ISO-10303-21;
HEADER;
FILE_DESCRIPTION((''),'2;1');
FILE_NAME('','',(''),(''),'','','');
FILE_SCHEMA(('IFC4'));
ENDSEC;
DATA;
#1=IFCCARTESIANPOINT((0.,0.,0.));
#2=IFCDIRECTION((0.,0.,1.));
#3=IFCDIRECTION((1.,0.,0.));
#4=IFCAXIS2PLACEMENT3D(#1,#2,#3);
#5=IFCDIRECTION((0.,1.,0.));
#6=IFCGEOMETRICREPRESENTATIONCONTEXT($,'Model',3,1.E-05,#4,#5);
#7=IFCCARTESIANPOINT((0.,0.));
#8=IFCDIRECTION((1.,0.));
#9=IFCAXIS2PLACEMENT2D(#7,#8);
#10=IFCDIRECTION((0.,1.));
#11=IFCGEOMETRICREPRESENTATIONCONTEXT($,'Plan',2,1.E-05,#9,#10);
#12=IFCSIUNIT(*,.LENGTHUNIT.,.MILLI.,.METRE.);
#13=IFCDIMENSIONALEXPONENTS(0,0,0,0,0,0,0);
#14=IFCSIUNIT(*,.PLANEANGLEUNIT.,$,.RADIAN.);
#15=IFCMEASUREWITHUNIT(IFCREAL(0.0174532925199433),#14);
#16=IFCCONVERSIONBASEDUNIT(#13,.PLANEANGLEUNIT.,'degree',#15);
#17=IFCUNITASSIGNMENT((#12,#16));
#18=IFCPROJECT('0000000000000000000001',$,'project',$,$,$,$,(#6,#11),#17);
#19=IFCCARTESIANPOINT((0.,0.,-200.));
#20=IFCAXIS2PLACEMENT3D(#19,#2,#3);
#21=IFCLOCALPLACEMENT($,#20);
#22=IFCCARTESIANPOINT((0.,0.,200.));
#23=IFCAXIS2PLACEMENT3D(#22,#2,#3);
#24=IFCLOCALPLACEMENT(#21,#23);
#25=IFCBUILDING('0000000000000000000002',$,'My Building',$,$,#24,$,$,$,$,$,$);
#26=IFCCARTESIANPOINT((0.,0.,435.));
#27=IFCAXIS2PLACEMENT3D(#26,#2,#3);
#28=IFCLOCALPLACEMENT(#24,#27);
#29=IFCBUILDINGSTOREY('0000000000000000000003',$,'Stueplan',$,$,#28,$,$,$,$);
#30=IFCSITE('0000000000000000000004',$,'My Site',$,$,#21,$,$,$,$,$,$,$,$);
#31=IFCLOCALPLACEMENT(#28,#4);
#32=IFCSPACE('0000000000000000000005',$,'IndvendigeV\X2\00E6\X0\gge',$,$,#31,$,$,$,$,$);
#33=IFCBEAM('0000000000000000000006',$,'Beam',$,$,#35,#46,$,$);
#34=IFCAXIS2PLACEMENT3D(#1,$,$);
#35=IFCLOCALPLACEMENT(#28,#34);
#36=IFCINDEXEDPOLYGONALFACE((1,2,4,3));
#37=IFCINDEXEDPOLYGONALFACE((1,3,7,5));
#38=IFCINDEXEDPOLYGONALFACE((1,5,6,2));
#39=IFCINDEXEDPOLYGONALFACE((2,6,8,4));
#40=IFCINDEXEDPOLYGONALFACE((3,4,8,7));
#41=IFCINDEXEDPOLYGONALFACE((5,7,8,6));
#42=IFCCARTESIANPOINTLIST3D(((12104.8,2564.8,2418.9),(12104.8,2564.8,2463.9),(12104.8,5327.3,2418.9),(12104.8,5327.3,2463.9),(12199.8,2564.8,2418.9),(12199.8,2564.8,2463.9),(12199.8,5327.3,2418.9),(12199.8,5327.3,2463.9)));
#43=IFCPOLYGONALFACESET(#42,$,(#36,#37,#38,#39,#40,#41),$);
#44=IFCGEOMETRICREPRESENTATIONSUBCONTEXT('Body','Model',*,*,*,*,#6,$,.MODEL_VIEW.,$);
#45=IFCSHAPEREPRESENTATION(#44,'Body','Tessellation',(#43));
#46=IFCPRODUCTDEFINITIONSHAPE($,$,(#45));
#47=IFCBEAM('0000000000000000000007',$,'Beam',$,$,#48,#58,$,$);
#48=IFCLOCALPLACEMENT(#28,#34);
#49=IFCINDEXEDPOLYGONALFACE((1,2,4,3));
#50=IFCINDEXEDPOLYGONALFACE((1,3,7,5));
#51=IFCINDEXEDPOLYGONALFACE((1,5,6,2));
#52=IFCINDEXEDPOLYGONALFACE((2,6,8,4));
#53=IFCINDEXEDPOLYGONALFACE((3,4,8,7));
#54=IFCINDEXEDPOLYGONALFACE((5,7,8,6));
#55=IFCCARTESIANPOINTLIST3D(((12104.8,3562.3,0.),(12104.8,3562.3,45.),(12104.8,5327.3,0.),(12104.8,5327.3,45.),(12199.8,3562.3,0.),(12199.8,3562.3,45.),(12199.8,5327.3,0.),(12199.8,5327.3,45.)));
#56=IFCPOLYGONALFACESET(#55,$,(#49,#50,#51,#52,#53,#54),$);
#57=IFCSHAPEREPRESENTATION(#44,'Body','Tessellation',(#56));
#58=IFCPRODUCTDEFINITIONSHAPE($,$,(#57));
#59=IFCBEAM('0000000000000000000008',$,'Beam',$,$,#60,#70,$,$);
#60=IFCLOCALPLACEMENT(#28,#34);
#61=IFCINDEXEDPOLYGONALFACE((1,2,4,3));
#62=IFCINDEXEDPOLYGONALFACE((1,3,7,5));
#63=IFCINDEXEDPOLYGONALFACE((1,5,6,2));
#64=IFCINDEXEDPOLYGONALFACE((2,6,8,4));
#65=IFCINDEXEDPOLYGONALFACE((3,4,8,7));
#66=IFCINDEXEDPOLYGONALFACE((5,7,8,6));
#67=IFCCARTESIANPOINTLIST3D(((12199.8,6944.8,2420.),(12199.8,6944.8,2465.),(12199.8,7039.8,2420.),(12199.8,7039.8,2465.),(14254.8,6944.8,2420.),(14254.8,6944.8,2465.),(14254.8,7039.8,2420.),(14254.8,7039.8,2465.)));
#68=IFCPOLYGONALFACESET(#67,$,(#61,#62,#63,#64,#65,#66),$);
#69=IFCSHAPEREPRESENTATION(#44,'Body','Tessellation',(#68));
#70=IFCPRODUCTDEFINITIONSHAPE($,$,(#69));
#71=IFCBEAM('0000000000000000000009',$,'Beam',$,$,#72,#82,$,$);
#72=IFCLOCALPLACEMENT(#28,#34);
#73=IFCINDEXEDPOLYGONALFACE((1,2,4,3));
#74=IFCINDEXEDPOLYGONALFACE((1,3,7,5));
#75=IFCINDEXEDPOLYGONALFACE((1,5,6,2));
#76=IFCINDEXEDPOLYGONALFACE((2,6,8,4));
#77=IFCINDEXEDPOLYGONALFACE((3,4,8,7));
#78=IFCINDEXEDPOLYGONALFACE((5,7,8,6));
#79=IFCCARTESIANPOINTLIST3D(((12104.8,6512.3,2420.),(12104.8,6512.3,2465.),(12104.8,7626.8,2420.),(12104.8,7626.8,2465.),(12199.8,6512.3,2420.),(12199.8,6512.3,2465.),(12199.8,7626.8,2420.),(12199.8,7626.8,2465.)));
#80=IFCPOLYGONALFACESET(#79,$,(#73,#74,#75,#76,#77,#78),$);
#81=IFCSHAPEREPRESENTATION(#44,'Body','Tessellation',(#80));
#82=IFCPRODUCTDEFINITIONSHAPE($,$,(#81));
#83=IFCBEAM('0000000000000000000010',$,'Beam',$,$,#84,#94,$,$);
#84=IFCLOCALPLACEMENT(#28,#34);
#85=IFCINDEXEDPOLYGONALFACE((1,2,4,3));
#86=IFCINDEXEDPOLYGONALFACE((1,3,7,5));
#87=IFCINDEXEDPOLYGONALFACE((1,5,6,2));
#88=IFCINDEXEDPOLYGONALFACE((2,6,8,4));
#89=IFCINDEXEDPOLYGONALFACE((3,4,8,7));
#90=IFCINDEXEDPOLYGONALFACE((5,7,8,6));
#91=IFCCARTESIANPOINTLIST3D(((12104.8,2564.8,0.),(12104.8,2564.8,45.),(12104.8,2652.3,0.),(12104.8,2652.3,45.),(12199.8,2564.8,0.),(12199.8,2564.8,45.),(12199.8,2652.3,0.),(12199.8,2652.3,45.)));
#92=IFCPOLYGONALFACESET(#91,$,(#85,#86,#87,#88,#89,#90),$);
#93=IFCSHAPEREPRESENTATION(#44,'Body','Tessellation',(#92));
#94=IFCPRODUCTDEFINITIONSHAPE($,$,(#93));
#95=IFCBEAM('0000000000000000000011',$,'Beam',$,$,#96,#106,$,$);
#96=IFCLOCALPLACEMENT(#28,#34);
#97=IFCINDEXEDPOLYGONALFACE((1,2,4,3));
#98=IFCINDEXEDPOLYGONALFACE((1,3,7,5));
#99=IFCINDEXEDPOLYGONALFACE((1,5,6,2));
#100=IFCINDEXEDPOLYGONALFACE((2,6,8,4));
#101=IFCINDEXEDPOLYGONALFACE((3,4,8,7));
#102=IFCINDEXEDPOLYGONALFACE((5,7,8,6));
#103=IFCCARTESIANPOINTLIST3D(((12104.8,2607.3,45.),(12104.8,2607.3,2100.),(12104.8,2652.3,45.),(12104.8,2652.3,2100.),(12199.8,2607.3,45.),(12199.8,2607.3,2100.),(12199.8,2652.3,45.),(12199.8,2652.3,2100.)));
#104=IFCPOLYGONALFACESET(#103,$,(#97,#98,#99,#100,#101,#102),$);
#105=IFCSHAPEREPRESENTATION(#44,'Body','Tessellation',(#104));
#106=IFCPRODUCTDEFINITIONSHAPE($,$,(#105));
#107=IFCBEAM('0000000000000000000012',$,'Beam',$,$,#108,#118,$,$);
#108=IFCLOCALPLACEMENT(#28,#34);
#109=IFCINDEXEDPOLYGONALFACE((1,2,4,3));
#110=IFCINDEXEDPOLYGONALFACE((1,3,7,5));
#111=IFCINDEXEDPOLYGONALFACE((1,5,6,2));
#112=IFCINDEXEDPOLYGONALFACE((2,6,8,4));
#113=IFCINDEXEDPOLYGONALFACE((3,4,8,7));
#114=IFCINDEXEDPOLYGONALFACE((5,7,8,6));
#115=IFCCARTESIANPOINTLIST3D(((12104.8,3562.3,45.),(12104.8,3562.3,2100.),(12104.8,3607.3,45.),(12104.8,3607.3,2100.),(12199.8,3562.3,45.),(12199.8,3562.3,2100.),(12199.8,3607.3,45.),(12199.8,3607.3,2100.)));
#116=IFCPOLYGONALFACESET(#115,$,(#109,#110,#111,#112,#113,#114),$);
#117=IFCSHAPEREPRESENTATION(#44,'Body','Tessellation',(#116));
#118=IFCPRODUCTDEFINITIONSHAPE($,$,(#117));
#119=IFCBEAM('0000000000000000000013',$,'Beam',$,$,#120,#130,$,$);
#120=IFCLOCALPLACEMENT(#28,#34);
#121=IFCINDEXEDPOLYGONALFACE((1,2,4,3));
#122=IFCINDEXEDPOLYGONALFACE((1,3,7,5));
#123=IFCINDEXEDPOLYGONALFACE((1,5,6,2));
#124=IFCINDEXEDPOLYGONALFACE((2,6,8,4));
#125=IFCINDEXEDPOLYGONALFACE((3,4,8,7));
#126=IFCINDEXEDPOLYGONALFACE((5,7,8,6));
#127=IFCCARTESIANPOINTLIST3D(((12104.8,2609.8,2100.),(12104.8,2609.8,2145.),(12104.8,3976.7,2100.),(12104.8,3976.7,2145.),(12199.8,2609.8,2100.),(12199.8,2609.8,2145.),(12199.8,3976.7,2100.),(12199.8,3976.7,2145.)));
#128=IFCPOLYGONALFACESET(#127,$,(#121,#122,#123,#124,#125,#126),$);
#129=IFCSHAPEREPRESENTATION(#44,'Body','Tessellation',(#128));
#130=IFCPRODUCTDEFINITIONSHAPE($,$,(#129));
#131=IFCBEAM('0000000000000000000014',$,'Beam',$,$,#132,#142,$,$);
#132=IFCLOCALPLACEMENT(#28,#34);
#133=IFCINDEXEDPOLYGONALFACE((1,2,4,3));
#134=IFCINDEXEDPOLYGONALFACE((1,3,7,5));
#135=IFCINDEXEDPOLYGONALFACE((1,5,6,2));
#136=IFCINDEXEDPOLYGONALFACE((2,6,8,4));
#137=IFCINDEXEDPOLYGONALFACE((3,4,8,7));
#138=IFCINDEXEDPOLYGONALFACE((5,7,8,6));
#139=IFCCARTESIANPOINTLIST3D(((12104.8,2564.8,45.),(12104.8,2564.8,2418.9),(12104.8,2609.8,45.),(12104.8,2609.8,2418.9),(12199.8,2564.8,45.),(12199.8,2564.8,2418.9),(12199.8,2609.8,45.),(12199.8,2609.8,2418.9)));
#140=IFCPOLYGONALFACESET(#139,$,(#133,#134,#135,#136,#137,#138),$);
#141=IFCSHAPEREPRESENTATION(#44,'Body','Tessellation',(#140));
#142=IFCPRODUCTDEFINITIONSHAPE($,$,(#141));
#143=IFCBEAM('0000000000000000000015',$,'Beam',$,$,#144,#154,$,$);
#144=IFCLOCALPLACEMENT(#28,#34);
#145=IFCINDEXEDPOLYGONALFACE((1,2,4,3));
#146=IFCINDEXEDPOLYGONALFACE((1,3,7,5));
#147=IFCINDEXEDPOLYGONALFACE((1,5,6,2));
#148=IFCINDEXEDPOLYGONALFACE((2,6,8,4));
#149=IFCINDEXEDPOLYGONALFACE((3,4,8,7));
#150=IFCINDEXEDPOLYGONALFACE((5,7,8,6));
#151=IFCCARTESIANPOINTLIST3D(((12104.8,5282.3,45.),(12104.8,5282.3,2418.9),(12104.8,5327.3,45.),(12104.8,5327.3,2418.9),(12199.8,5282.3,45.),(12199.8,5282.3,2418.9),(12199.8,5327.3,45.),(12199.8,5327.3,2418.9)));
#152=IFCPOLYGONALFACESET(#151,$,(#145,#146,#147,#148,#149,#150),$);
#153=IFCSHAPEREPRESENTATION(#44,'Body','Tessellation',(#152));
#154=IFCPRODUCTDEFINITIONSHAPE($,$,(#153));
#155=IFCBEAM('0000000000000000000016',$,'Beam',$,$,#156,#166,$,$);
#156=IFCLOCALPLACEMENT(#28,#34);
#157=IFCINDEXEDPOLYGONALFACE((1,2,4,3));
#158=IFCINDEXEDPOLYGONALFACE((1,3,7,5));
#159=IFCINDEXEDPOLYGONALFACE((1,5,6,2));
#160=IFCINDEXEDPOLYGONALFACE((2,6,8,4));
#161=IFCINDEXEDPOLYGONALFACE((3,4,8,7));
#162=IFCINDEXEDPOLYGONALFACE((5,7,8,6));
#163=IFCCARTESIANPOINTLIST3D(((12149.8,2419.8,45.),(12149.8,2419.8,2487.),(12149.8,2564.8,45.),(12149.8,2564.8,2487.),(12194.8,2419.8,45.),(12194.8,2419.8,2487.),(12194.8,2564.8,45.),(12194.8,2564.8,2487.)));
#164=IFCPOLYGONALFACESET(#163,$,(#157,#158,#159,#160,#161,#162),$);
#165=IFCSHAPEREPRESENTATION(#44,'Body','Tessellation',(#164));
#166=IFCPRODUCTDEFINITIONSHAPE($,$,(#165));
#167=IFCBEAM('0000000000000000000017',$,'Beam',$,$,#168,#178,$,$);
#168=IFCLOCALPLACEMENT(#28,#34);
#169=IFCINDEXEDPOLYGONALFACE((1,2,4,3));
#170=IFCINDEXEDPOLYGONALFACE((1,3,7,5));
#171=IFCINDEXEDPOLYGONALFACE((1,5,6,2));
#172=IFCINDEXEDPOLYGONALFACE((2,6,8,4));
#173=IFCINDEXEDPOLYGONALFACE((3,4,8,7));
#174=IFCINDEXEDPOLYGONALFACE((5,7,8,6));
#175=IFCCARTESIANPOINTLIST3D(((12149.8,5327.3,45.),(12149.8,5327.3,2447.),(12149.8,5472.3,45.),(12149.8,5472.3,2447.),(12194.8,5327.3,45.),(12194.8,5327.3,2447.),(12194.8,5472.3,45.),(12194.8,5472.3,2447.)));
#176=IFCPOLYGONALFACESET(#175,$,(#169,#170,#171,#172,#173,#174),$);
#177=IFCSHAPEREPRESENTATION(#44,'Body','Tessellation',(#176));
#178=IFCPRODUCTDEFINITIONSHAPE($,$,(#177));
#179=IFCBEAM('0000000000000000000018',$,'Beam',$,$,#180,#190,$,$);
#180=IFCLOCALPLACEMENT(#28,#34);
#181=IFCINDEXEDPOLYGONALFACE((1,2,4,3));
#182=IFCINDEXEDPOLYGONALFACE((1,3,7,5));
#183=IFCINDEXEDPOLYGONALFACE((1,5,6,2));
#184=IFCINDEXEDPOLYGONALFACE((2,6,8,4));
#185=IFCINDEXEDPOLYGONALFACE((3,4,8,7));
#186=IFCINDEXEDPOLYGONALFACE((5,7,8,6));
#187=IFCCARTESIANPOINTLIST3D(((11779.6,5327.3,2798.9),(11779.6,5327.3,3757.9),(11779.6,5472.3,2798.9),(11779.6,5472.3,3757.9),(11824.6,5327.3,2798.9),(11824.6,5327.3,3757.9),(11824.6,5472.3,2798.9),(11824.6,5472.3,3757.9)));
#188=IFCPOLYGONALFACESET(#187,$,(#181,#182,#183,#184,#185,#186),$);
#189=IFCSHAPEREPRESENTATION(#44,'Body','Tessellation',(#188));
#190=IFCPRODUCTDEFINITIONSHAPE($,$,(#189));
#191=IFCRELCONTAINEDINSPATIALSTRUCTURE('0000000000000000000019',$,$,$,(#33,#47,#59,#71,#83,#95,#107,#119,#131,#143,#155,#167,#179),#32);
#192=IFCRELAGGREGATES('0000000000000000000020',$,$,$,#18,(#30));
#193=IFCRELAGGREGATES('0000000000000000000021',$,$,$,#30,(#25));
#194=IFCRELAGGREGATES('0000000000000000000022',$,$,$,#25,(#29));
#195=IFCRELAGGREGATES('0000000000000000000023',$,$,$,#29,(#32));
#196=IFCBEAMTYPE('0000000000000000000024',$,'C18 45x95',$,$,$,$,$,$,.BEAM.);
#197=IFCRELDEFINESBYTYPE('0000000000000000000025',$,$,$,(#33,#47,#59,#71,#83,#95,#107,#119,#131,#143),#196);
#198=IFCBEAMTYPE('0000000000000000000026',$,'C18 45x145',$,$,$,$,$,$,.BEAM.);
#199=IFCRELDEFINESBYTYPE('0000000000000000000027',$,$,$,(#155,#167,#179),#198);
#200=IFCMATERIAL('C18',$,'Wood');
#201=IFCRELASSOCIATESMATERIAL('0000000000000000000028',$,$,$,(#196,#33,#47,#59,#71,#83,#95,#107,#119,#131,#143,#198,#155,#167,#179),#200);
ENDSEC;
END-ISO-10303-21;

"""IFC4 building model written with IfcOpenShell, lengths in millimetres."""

from ifc_helpers import new_model, entity, si_unit, converted_unit, direction, frame, origin_with_axes, origin_2d_with_axis, place, context, subcontext, project, spatial, rectangle, extrude, material, material_profile, profile_set, profile_usage, type_object, element, save


model = new_model("IFC4")

# Units and contexts
model_context = context("Model", 3, precision=1e-05, world=origin_with_axes(), true_north=direction((0.0, 1.0, 0.0)))
plan_context = context("Plan", 2, precision=1e-05, world=origin_2d_with_axis(), true_north=direction((0.0, 1.0)))
body_context_1 = subcontext(model_context, "Body", "Model", "MODEL_VIEW")
ifc_project = project(units=[si_unit("LENGTHUNIT", "METRE", prefix="MILLI"), converted_unit("PLANEANGLEUNIT", "degree", entity("IfcReal", 0.0174532925199433), si_unit("PLANEANGLEUNIT", "RADIAN"), dimensions=[0, 0, 0, 0, 0, 0, 0])], contexts=[model_context, plan_context])

# Site, building, storey, space
site_placement = place(None, frame((0.0, 0.0, -200.0), z_axis=(0.0, 0.0, 1.0), x_axis=(1.0, 0.0, 0.0)))
site = spatial("IfcSite", under=ifc_project, at=site_placement, Name="My Site")
building_placement = place(site_placement, frame((0.0, 0.0, 200.0), z_axis=(0.0, 0.0, 1.0), x_axis=(1.0, 0.0, 0.0)))
building = spatial("IfcBuilding", under=site, at=building_placement, Name="My Building")
storey_placement = place(building_placement, frame((0.0, 0.0, 435.0), z_axis=(0.0, 0.0, 1.0), x_axis=(1.0, 0.0, 0.0)))
storey = spatial("IfcBuildingStorey", under=building, at=storey_placement, Name="Stueplan")
space_1_placement = place(storey_placement, frame((0.0, 0.0, 0.0), z_axis=(0.0, 0.0, 1.0), x_axis=(1.0, 0.0, 0.0)))
space_1 = spatial("IfcSpace", under=storey, at=space_1_placement, Name="IndvendigeVægge")

# Beams
ifc_material = material(Name="C18", Category="Wood")
ifc_material_profile_1 = material_profile(ifc_material, rectangle(XDim=45.0, YDim=95.0))
ifc_profile_set_1 = profile_set([ifc_material_profile_1], Name="woodStructural")
beam_type_1 = type_object("IfcBeamType", Name="C18 45x95", PredefinedType="BEAM", material=ifc_profile_set_1)
ifc_profile_usage_1 = profile_usage(ifc_profile_set_1, cardinal=5)
beam_1_placement = place(space_1_placement, frame((12152.3, 2564.8, 2441.4), z_axis=(0.0, 1.0, 0.0), x_axis=(0.0, 0.0, 1.0)))
element("IfcBeam", 1, at=beam_1_placement, inside=space_1, type_object=beam_type_1, material=ifc_profile_usage_1, Name="Beam", context=body_context_1, shape_type="SweptSolid", body=[
    extrude(rectangle(XDim=45.0, YDim=95.0), origin_with_axes(), (0.0, 0.0, 1.0), 2762.5),
])
ifc_profile_usage_2 = profile_usage(ifc_profile_set_1, cardinal=5)
beam_2_placement = place(space_1_placement, frame((12152.3, 3562.3, 22.5), z_axis=(0.0, 1.0, 0.0), x_axis=(0.0, 0.0, 1.0)))
element("IfcBeam", 2, at=beam_2_placement, inside=space_1, type_object=beam_type_1, material=ifc_profile_usage_2, Name="Beam", context=body_context_1, shape_type="SweptSolid", body=[
    extrude(rectangle(XDim=45.0, YDim=95.0), origin_with_axes(), (0.0, 0.0, 1.0), 1765.0),
])
ifc_profile_usage_3 = profile_usage(ifc_profile_set_1, cardinal=5)
beam_3_placement = place(space_1_placement, frame((12199.8, 6992.3, 2442.5), z_axis=(1.0, 0.0, 0.0), x_axis=(0.0, 0.0, 1.0)))
element("IfcBeam", 3, at=beam_3_placement, inside=space_1, type_object=beam_type_1, material=ifc_profile_usage_3, Name="Beam", context=body_context_1, shape_type="SweptSolid", body=[
    extrude(rectangle(XDim=45.0, YDim=95.0), origin_with_axes(), (0.0, 0.0, 1.0), 2055.0),
])
ifc_profile_usage_4 = profile_usage(ifc_profile_set_1, cardinal=5)
beam_4_placement = place(space_1_placement, frame((12152.3, 6512.3, 2442.5), z_axis=(0.0, 1.0, 0.0), x_axis=(0.0, 0.0, 1.0)))
element("IfcBeam", 4, at=beam_4_placement, inside=space_1, type_object=beam_type_1, material=ifc_profile_usage_4, Name="Beam", context=body_context_1, shape_type="SweptSolid", body=[
    extrude(rectangle(XDim=45.0, YDim=95.0), origin_with_axes(), (0.0, 0.0, 1.0), 1114.5),
])
ifc_profile_usage_5 = profile_usage(ifc_profile_set_1, cardinal=5)
beam_5_placement = place(space_1_placement, frame((12152.3, 2652.3, 22.5), z_axis=(0.0, -1.0, 0.0), x_axis=(0.0, 0.0, 1.0)))
element("IfcBeam", 5, at=beam_5_placement, inside=space_1, type_object=beam_type_1, material=ifc_profile_usage_5, Name="Beam", context=body_context_1, shape_type="SweptSolid", body=[
    extrude(rectangle(XDim=45.0, YDim=95.0), origin_with_axes(), (0.0, 0.0, 1.0), 87.5),
])
ifc_profile_usage_6 = profile_usage(ifc_profile_set_1)
beam_6_placement = place(space_1_placement, frame((12152.3, 2629.8, 45.0), z_axis=(0.0, 0.0, 1.0), x_axis=(0.0, -1.0, 0.0)))
element("IfcBeam", 6, at=beam_6_placement, inside=space_1, type_object=beam_type_1, material=ifc_profile_usage_6, Name="Beam", context=body_context_1, shape_type="SweptSolid", body=[
    extrude(rectangle(XDim=45.0, YDim=95.0), origin_with_axes(), (0.0, 0.0, 1.0), 2055.0),
])
ifc_profile_usage_7 = profile_usage(ifc_profile_set_1)
beam_7_placement = place(space_1_placement, frame((12152.3, 3584.8, 45.0), z_axis=(0.0, 0.0, 1.0), x_axis=(0.0, -1.0, 0.0)))
element("IfcBeam", 7, at=beam_7_placement, inside=space_1, type_object=beam_type_1, material=ifc_profile_usage_7, Name="Beam", context=body_context_1, shape_type="SweptSolid", body=[
    extrude(rectangle(XDim=45.0, YDim=95.0), origin_with_axes(), (0.0, 0.0, 1.0), 2055.0),
])
ifc_profile_usage_8 = profile_usage(ifc_profile_set_1, cardinal=5)
beam_8_placement = place(space_1_placement, frame((12152.3, 3976.7, 2122.5), z_axis=(0.0, -1.0, 0.0), x_axis=(0.0, 0.0, 1.0)))
element("IfcBeam", 8, at=beam_8_placement, inside=space_1, type_object=beam_type_1, material=ifc_profile_usage_8, Name="Beam", context=body_context_1, shape_type="SweptSolid", body=[
    extrude(rectangle(XDim=45.0, YDim=95.0), origin_with_axes(), (0.0, 0.0, 1.0), 1366.9),
])
ifc_profile_usage_9 = profile_usage(ifc_profile_set_1)
beam_9_placement = place(space_1_placement, frame((12152.3, 2587.3, 45.0), z_axis=(0.0, 0.0, 1.0), x_axis=(0.0, -1.0, 0.0)))
element("IfcBeam", 9, at=beam_9_placement, inside=space_1, type_object=beam_type_1, material=ifc_profile_usage_9, Name="Beam", context=body_context_1, shape_type="SweptSolid", body=[
    extrude(rectangle(XDim=45.0, YDim=95.0), origin_with_axes(), (0.0, 0.0, 1.0), 2373.9),
])
ifc_profile_usage_10 = profile_usage(ifc_profile_set_1)
beam_10_placement = place(space_1_placement, frame((12152.3, 5304.8, 45.0), z_axis=(0.0, 0.0, 1.0), x_axis=(0.0, -1.0, 0.0)))
element("IfcBeam", 10, at=beam_10_placement, inside=space_1, type_object=beam_type_1, material=ifc_profile_usage_10, Name="Beam", context=body_context_1, shape_type="SweptSolid", body=[
    extrude(rectangle(XDim=45.0, YDim=95.0), origin_with_axes(), (0.0, 0.0, 1.0), 2373.9),
])
ifc_material_profile_2 = material_profile(ifc_material, rectangle(XDim=45.0, YDim=145.0))
ifc_profile_set_2 = profile_set([ifc_material_profile_2], Name="woodStructural")
ifc_profile_usage_11 = profile_usage(ifc_profile_set_2)
beam_type_2 = type_object("IfcBeamType", Name="C18 45x145", PredefinedType="BEAM", material=ifc_profile_set_2)
beam_11_placement = place(space_1_placement, frame((12172.3, 2492.3, 45.0), z_axis=(0.0, 0.0, 1.0), x_axis=(-1.0, 0.0, 0.0)))
element("IfcBeam", 11, at=beam_11_placement, inside=space_1, type_object=beam_type_2, material=ifc_profile_usage_11, Name="Beam", context=body_context_1, shape_type="SweptSolid", body=[
    extrude(rectangle(XDim=45.0, YDim=145.0), origin_with_axes(), (0.0, 0.0, 1.0), 2442.0),
])
ifc_profile_usage_12 = profile_usage(ifc_profile_set_2)
beam_12_placement = place(space_1_placement, frame((12172.3, 5399.8, 45.0), z_axis=(0.0, 0.0, 1.0), x_axis=(-1.0, 0.0, 0.0)))
element("IfcBeam", 12, at=beam_12_placement, inside=space_1, type_object=beam_type_2, material=ifc_profile_usage_12, Name="Beam", context=body_context_1, shape_type="SweptSolid", body=[
    extrude(rectangle(XDim=45.0, YDim=145.0), origin_with_axes(), (0.0, 0.0, 1.0), 2402.0),
])
ifc_profile_usage_13 = profile_usage(ifc_profile_set_2)
beam_13_placement = place(space_1_placement, frame((11802.1, 5399.8, 2798.9), z_axis=(0.0, 0.0, 1.0), x_axis=(-1.0, 0.0, 0.0)))
element("IfcBeam", 13, at=beam_13_placement, inside=space_1, type_object=beam_type_2, material=ifc_profile_usage_13, Name="Beam", context=body_context_1, shape_type="SweptSolid", body=[
    extrude(rectangle(XDim=45.0, YDim=145.0), origin_with_axes(), (0.0, 0.0, 1.0), 958.9),
])

save(model, "model.ifc")
